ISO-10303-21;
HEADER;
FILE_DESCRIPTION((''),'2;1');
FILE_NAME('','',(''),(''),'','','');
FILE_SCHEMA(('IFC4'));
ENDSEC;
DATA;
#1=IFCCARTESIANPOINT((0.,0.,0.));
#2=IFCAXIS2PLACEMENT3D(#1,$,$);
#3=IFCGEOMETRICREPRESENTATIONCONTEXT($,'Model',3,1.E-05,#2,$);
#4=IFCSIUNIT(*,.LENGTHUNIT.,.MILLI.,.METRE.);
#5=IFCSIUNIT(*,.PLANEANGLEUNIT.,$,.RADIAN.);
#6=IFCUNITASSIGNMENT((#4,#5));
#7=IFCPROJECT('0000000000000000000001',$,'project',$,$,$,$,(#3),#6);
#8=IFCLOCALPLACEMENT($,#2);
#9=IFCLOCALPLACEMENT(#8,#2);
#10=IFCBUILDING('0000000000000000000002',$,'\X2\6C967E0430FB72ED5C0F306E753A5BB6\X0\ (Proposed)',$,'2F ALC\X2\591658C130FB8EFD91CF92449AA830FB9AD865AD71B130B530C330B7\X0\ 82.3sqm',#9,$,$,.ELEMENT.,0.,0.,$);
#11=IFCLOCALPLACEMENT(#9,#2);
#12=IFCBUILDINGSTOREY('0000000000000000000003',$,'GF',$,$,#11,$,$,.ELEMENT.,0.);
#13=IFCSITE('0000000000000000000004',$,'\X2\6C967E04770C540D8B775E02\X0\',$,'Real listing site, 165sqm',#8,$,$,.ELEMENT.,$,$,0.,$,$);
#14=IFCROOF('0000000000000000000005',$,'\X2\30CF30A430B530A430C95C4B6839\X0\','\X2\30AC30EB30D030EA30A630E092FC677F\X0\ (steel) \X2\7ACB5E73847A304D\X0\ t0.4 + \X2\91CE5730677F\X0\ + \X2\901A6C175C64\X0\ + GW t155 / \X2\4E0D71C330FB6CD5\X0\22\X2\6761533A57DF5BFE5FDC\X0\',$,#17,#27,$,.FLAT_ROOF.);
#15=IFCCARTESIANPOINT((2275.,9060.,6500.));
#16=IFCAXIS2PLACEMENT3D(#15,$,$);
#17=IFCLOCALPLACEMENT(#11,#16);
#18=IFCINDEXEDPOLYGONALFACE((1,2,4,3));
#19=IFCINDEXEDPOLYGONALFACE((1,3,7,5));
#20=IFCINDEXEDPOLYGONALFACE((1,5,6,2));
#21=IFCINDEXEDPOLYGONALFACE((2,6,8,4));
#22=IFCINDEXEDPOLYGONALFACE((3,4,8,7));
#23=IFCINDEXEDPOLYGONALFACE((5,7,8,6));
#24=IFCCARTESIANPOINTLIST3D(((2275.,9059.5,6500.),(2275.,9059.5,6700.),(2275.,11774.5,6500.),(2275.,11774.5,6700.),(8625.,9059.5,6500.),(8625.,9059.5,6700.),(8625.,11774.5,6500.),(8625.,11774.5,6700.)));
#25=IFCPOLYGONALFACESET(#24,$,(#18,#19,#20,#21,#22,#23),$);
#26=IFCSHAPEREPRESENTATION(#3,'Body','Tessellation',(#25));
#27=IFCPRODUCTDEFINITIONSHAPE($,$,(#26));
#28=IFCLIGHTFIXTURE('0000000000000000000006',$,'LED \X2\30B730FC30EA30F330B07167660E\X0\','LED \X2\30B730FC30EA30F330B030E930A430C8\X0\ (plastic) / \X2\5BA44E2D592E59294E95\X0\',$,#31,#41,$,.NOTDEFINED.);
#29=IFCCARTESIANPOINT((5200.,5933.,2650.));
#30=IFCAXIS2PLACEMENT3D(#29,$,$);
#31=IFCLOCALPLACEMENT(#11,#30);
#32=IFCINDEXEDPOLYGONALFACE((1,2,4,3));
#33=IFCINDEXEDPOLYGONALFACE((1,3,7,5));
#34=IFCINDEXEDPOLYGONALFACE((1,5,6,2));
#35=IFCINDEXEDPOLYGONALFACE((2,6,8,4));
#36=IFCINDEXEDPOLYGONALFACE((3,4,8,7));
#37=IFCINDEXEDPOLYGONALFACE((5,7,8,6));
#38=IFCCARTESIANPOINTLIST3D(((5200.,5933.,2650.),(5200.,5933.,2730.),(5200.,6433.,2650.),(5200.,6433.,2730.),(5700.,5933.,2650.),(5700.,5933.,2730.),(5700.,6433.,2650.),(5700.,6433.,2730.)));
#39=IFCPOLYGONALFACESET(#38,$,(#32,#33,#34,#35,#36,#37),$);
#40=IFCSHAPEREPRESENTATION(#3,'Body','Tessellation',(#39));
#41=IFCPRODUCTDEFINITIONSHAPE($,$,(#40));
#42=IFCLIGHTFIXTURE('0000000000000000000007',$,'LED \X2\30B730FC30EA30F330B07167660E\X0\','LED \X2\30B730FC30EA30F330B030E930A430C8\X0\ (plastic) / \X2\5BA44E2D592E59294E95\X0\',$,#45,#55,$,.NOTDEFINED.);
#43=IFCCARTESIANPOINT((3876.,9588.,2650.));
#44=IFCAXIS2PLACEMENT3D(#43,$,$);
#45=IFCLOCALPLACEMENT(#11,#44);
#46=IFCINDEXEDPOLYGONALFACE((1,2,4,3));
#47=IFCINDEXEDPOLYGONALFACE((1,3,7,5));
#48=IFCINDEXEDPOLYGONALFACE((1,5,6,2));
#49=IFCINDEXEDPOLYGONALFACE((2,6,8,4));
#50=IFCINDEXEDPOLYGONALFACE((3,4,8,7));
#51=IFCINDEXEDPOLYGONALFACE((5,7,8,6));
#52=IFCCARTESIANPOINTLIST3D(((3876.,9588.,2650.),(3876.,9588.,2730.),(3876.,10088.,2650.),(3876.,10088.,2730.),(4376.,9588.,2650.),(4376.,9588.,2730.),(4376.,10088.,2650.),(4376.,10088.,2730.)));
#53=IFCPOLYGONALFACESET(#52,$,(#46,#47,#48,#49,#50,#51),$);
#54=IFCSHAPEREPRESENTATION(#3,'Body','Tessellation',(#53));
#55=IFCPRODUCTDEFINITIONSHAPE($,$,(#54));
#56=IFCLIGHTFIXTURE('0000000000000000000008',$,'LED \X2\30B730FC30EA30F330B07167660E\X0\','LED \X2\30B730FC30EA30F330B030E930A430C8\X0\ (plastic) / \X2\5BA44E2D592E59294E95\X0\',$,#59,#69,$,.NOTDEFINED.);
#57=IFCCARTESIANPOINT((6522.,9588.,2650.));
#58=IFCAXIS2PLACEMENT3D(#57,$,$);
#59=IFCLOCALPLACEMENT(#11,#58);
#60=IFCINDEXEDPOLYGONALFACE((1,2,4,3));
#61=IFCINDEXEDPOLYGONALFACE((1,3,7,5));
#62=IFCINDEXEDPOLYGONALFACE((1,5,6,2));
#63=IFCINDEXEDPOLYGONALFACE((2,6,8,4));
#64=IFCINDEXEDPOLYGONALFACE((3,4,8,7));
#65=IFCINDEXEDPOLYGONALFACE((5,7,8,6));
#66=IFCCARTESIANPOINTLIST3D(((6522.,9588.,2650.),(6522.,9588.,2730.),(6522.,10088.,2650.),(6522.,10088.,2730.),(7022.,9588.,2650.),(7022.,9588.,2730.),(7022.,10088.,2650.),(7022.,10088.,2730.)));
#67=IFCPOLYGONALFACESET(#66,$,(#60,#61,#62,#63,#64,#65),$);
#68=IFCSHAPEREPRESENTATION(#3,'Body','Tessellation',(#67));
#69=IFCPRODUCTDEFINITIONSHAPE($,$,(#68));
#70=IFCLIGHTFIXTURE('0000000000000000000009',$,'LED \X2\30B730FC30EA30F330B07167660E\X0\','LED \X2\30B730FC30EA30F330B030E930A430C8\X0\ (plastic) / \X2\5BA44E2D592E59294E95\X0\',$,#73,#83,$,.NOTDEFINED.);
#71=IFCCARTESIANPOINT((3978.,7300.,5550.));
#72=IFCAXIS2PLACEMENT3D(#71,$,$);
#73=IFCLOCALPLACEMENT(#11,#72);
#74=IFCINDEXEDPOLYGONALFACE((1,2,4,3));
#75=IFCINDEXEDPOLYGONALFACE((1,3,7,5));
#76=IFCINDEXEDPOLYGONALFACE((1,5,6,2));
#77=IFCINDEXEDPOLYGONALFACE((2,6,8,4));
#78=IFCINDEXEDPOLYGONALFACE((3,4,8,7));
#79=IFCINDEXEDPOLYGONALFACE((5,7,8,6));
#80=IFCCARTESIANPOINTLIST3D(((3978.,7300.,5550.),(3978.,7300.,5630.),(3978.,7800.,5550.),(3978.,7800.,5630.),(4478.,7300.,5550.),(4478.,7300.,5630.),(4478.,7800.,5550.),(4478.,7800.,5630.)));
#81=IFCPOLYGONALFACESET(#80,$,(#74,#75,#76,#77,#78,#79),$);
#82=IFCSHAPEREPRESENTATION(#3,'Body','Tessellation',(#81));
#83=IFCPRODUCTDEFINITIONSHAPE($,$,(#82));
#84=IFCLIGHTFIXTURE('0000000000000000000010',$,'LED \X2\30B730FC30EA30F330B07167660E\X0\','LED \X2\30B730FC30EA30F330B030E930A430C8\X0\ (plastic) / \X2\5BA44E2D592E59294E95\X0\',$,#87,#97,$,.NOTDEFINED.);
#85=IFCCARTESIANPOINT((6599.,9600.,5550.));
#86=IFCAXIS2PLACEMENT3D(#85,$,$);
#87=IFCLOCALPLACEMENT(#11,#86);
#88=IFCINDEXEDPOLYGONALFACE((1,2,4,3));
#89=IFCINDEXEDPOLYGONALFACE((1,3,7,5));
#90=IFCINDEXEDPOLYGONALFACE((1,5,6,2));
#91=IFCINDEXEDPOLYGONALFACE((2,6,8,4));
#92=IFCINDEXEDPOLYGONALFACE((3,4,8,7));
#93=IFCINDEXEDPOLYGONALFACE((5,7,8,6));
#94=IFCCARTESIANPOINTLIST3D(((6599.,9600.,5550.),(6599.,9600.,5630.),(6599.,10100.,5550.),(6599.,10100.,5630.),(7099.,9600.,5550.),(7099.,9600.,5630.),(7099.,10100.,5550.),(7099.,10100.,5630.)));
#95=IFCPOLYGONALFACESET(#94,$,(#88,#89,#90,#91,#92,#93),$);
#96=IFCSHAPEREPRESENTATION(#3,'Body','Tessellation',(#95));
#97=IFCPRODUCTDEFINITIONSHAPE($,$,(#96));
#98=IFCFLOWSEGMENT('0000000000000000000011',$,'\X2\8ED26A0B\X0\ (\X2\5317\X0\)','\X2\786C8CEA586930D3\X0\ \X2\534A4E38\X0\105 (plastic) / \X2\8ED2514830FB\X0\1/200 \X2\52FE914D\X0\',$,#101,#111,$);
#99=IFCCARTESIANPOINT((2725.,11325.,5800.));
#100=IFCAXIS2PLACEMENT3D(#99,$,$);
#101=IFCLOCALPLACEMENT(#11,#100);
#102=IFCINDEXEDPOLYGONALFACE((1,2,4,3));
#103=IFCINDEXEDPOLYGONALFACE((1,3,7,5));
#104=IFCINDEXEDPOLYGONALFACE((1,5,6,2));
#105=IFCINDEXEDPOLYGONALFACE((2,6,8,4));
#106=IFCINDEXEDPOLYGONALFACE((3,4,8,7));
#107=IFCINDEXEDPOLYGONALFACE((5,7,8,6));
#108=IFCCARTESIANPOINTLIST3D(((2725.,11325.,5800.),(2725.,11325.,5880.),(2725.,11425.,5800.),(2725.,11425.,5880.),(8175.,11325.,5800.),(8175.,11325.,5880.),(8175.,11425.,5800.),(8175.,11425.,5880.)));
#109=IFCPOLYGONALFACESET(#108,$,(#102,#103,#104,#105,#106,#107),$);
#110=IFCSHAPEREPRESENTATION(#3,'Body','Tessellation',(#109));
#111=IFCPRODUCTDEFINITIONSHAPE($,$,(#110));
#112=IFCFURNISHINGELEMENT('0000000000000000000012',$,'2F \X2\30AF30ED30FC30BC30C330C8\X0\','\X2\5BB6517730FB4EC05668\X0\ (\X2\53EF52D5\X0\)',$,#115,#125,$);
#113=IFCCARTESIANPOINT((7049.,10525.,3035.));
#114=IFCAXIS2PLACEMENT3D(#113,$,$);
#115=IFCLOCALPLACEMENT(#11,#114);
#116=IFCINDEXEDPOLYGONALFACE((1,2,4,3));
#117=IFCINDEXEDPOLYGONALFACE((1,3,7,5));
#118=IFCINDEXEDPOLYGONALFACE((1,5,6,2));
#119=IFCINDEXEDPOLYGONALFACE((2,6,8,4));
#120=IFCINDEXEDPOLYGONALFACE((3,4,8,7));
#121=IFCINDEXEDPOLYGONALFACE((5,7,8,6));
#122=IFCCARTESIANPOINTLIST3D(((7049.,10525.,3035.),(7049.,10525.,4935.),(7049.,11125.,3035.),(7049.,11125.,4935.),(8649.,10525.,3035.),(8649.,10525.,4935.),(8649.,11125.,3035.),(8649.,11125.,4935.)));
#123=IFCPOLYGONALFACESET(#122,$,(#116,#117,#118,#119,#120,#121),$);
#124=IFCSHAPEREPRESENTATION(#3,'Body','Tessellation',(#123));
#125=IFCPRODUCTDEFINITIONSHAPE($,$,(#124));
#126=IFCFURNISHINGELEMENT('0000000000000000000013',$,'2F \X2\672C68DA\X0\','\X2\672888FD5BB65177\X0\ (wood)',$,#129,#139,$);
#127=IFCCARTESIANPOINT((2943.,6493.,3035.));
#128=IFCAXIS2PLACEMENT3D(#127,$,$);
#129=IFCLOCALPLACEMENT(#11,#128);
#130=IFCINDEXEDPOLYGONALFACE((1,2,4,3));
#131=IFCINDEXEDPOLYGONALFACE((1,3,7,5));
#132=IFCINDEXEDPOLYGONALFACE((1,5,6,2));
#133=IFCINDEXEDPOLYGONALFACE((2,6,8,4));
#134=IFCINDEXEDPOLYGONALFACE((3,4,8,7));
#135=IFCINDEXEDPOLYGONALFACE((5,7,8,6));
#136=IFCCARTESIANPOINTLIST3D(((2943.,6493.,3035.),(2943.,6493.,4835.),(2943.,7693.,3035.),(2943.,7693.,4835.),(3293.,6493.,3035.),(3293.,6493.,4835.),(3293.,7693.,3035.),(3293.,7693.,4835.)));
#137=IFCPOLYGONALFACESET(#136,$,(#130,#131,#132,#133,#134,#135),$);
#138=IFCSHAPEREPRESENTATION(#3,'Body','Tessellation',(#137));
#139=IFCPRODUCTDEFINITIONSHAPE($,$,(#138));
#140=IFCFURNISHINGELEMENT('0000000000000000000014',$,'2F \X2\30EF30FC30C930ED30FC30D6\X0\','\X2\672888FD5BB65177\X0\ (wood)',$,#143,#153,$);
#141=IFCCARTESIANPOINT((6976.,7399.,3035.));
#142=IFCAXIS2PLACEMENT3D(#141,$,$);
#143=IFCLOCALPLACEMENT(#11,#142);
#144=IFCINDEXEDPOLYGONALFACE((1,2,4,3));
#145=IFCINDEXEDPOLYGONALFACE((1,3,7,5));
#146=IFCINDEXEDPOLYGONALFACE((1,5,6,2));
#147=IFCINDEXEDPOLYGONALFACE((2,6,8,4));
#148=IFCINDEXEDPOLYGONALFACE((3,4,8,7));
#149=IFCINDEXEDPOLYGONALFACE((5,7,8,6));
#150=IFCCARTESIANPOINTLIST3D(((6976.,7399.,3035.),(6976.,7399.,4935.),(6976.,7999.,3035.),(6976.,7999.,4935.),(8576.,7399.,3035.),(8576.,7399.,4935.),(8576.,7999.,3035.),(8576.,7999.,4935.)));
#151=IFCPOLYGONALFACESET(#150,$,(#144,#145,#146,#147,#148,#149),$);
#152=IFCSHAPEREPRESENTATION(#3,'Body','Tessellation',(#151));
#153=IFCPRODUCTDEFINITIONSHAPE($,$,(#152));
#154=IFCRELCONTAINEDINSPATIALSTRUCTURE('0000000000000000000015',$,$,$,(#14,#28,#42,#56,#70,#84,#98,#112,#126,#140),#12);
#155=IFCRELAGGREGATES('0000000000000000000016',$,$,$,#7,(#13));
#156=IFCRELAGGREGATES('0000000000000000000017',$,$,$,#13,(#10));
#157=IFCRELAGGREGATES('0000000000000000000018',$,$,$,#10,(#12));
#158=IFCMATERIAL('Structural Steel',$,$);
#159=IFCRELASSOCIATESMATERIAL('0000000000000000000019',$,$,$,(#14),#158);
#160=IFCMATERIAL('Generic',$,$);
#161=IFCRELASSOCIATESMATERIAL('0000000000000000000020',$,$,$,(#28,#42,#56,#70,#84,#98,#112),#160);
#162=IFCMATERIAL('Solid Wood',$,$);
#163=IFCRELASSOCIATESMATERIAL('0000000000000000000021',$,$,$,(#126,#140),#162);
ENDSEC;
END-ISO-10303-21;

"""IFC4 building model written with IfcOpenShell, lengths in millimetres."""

from ifc_helpers import new_model, si_unit, frame, frame_2d, origin, place, context, project, spatial, rectangle, extrude, material, element, save


model = new_model("IFC4")

# Units and contexts
model_context = context("Model", 3, precision=1e-05, world=origin())
ifc_project = project(units=[si_unit("LENGTHUNIT", "METRE", prefix="MILLI"), si_unit("PLANEANGLEUNIT", "RADIAN")], contexts=[model_context])

# Site, building, storey
site_placement = place(None, origin())
site = spatial("IfcSite", under=ifc_project, at=site_placement, Name="沖縄県名護市", ObjectType="Real listing site, 165sqm", CompositionType="ELEMENT", RefElevation=0.0)
building_placement = place(site_placement, origin())
building = spatial("IfcBuilding", under=site, at=building_placement, Name="沖縄・狭小の町家 (Proposed)", ObjectType="2F ALC外壁・軽量鉄骨・高断熱サッシ 82.3sqm", CompositionType="ELEMENT", ElevationOfRefHeight=0.0, ElevationOfTerrain=0.0)
storey_placement = place(building_placement, origin())
storey = spatial("IfcBuildingStorey", under=building, at=storey_placement, Name="GF", CompositionType="ELEMENT", Elevation=0.0)

# Shared definitions
ifc_material_1 = material(Name="Solid Wood")

# Roof
ifc_material_2 = material(Name="Structural Steel")
roof_placement = place(storey_placement, frame((2275.0, 9060.0, 6500.0)))
element("IfcRoof", 1, at=roof_placement, inside=storey, material=ifc_material_2, Name="ハイサイド屋根", Description="ガルバリウム鋼板 (steel) 立平葺き t0.4 + 野地板 + 通気層 + GW t155 / 不燃・法22条区域対応", PredefinedType="FLAT_ROOF", context=model_context, shape_type="SweptSolid", body=[
    extrude(rectangle(XDim=6350.0, YDim=2715.0, at=frame_2d((3175.0, 1357.0))), frame((2275.0, 9060.0, 6500.0)), (0.0, 0.0, 1.0), 200.0),
])

# Light fixtures
ifc_material_3 = material(Name="Generic")
light_fixture_1_placement = place(storey_placement, frame((5200.0, 5933.0, 2650.0)))
element("IfcLightFixture", 2, at=light_fixture_1_placement, inside=storey, material=ifc_material_3, Name="LED シーリング照明", Description="LED シーリングライト (plastic) / 室中央天井", PredefinedType="NOTDEFINED", context=model_context, shape_type="SweptSolid", body=[
    extrude(rectangle(XDim=500.0, YDim=500.0, at=frame_2d((250.0, 250.0))), frame((5200.0, 5933.0, 2650.0)), (0.0, 0.0, 1.0), 80.0),
])
light_fixture_2_placement = place(storey_placement, frame((3876.0, 9588.0, 2650.0)))
element("IfcLightFixture", 3, at=light_fixture_2_placement, inside=storey, material=ifc_material_3, Name="LED シーリング照明", Description="LED シーリングライト (plastic) / 室中央天井", PredefinedType="NOTDEFINED", context=model_context, shape_type="SweptSolid", body=[
    extrude(rectangle(XDim=500.0, YDim=500.0, at=frame_2d((250.0, 250.0))), frame((3876.0, 9588.0, 2650.0)), (0.0, 0.0, 1.0), 80.0),
])
light_fixture_3_placement = place(storey_placement, frame((6522.0, 9588.0, 2650.0)))
element("IfcLightFixture", 4, at=light_fixture_3_placement, inside=storey, material=ifc_material_3, Name="LED シーリング照明", Description="LED シーリングライト (plastic) / 室中央天井", PredefinedType="NOTDEFINED", context=model_context, shape_type="SweptSolid", body=[
    extrude(rectangle(XDim=500.0, YDim=500.0, at=frame_2d((250.0, 250.0))), frame((6522.0, 9588.0, 2650.0)), (0.0, 0.0, 1.0), 80.0),
])
light_fixture_4_placement = place(storey_placement, frame((3978.0, 7300.0, 5550.0)))
element("IfcLightFixture", 5, at=light_fixture_4_placement, inside=storey, material=ifc_material_3, Name="LED シーリング照明", Description="LED シーリングライト (plastic) / 室中央天井", PredefinedType="NOTDEFINED", context=model_context, shape_type="SweptSolid", body=[
    extrude(rectangle(XDim=500.0, YDim=500.0, at=frame_2d((250.0, 250.0))), frame((3978.0, 7300.0, 5550.0)), (0.0, 0.0, 1.0), 80.0),
])
light_fixture_5_placement = place(storey_placement, frame((6599.0, 9600.0, 5550.0)))
element("IfcLightFixture", 6, at=light_fixture_5_placement, inside=storey, material=ifc_material_3, Name="LED シーリング照明", Description="LED シーリングライト (plastic) / 室中央天井", PredefinedType="NOTDEFINED", context=model_context, shape_type="SweptSolid", body=[
    extrude(rectangle(XDim=500.0, YDim=500.0, at=frame_2d((250.0, 250.0))), frame((6599.0, 9600.0, 5550.0)), (0.0, 0.0, 1.0), 80.0),
])

# Flow segment
flow_segment_placement = place(storey_placement, frame((2725.0, 11325.0, 5800.0)))
element("IfcFlowSegment", 7, at=flow_segment_placement, inside=storey, material=ifc_material_3, Name="軒樋 (北)", Description="硬質塩ビ 半丸105 (plastic) / 軒先・1/200 勾配", context=model_context, shape_type="SweptSolid", body=[
    extrude(rectangle(XDim=5450.0, YDim=100.0, at=frame_2d((2725.0, 50.0))), frame((2725.0, 11325.0, 5800.0)), (0.0, 0.0, 1.0), 80.0),
])

# Furnishing elements
furnishing_1_placement = place(storey_placement, frame((7049.0, 10525.0, 3035.0)))
element("IfcFurnishingElement", 8, at=furnishing_1_placement, inside=storey, material=ifc_material_3, Name="2F クローゼット", Description="家具・什器 (可動)", context=model_context, shape_type="SweptSolid", body=[
    extrude(rectangle(XDim=1600.0, YDim=600.0, at=frame_2d((800.0, 300.0))), frame((7049.0, 10525.0, 3035.0)), (0.0, 0.0, 1.0), 1900.0),
])
furnishing_2_placement = place(storey_placement, frame((2943.0, 6493.0, 3035.0)))
element("IfcFurnishingElement", 9, at=furnishing_2_placement, inside=storey, material=ifc_material_1, Name="2F 本棚", Description="木製家具 (wood)", context=model_context, shape_type="SweptSolid", body=[
    extrude(rectangle(XDim=350.0, YDim=1200.0, at=frame_2d((175.0, 600.0))), frame((2943.0, 6493.0, 3035.0)), (0.0, 0.0, 1.0), 1800.0),
])
furnishing_3_placement = place(storey_placement, frame((6976.0, 7399.0, 3035.0)))
element("IfcFurnishingElement", 10, at=furnishing_3_placement, inside=storey, material=ifc_material_1, Name="2F ワードローブ", Description="木製家具 (wood)", context=model_context, shape_type="SweptSolid", body=[
    extrude(rectangle(XDim=1600.0, YDim=600.0, at=frame_2d((800.0, 300.0))), frame((6976.0, 7399.0, 3035.0)), (0.0, 0.0, 1.0), 1900.0),
])

save(model, "model.ifc")
